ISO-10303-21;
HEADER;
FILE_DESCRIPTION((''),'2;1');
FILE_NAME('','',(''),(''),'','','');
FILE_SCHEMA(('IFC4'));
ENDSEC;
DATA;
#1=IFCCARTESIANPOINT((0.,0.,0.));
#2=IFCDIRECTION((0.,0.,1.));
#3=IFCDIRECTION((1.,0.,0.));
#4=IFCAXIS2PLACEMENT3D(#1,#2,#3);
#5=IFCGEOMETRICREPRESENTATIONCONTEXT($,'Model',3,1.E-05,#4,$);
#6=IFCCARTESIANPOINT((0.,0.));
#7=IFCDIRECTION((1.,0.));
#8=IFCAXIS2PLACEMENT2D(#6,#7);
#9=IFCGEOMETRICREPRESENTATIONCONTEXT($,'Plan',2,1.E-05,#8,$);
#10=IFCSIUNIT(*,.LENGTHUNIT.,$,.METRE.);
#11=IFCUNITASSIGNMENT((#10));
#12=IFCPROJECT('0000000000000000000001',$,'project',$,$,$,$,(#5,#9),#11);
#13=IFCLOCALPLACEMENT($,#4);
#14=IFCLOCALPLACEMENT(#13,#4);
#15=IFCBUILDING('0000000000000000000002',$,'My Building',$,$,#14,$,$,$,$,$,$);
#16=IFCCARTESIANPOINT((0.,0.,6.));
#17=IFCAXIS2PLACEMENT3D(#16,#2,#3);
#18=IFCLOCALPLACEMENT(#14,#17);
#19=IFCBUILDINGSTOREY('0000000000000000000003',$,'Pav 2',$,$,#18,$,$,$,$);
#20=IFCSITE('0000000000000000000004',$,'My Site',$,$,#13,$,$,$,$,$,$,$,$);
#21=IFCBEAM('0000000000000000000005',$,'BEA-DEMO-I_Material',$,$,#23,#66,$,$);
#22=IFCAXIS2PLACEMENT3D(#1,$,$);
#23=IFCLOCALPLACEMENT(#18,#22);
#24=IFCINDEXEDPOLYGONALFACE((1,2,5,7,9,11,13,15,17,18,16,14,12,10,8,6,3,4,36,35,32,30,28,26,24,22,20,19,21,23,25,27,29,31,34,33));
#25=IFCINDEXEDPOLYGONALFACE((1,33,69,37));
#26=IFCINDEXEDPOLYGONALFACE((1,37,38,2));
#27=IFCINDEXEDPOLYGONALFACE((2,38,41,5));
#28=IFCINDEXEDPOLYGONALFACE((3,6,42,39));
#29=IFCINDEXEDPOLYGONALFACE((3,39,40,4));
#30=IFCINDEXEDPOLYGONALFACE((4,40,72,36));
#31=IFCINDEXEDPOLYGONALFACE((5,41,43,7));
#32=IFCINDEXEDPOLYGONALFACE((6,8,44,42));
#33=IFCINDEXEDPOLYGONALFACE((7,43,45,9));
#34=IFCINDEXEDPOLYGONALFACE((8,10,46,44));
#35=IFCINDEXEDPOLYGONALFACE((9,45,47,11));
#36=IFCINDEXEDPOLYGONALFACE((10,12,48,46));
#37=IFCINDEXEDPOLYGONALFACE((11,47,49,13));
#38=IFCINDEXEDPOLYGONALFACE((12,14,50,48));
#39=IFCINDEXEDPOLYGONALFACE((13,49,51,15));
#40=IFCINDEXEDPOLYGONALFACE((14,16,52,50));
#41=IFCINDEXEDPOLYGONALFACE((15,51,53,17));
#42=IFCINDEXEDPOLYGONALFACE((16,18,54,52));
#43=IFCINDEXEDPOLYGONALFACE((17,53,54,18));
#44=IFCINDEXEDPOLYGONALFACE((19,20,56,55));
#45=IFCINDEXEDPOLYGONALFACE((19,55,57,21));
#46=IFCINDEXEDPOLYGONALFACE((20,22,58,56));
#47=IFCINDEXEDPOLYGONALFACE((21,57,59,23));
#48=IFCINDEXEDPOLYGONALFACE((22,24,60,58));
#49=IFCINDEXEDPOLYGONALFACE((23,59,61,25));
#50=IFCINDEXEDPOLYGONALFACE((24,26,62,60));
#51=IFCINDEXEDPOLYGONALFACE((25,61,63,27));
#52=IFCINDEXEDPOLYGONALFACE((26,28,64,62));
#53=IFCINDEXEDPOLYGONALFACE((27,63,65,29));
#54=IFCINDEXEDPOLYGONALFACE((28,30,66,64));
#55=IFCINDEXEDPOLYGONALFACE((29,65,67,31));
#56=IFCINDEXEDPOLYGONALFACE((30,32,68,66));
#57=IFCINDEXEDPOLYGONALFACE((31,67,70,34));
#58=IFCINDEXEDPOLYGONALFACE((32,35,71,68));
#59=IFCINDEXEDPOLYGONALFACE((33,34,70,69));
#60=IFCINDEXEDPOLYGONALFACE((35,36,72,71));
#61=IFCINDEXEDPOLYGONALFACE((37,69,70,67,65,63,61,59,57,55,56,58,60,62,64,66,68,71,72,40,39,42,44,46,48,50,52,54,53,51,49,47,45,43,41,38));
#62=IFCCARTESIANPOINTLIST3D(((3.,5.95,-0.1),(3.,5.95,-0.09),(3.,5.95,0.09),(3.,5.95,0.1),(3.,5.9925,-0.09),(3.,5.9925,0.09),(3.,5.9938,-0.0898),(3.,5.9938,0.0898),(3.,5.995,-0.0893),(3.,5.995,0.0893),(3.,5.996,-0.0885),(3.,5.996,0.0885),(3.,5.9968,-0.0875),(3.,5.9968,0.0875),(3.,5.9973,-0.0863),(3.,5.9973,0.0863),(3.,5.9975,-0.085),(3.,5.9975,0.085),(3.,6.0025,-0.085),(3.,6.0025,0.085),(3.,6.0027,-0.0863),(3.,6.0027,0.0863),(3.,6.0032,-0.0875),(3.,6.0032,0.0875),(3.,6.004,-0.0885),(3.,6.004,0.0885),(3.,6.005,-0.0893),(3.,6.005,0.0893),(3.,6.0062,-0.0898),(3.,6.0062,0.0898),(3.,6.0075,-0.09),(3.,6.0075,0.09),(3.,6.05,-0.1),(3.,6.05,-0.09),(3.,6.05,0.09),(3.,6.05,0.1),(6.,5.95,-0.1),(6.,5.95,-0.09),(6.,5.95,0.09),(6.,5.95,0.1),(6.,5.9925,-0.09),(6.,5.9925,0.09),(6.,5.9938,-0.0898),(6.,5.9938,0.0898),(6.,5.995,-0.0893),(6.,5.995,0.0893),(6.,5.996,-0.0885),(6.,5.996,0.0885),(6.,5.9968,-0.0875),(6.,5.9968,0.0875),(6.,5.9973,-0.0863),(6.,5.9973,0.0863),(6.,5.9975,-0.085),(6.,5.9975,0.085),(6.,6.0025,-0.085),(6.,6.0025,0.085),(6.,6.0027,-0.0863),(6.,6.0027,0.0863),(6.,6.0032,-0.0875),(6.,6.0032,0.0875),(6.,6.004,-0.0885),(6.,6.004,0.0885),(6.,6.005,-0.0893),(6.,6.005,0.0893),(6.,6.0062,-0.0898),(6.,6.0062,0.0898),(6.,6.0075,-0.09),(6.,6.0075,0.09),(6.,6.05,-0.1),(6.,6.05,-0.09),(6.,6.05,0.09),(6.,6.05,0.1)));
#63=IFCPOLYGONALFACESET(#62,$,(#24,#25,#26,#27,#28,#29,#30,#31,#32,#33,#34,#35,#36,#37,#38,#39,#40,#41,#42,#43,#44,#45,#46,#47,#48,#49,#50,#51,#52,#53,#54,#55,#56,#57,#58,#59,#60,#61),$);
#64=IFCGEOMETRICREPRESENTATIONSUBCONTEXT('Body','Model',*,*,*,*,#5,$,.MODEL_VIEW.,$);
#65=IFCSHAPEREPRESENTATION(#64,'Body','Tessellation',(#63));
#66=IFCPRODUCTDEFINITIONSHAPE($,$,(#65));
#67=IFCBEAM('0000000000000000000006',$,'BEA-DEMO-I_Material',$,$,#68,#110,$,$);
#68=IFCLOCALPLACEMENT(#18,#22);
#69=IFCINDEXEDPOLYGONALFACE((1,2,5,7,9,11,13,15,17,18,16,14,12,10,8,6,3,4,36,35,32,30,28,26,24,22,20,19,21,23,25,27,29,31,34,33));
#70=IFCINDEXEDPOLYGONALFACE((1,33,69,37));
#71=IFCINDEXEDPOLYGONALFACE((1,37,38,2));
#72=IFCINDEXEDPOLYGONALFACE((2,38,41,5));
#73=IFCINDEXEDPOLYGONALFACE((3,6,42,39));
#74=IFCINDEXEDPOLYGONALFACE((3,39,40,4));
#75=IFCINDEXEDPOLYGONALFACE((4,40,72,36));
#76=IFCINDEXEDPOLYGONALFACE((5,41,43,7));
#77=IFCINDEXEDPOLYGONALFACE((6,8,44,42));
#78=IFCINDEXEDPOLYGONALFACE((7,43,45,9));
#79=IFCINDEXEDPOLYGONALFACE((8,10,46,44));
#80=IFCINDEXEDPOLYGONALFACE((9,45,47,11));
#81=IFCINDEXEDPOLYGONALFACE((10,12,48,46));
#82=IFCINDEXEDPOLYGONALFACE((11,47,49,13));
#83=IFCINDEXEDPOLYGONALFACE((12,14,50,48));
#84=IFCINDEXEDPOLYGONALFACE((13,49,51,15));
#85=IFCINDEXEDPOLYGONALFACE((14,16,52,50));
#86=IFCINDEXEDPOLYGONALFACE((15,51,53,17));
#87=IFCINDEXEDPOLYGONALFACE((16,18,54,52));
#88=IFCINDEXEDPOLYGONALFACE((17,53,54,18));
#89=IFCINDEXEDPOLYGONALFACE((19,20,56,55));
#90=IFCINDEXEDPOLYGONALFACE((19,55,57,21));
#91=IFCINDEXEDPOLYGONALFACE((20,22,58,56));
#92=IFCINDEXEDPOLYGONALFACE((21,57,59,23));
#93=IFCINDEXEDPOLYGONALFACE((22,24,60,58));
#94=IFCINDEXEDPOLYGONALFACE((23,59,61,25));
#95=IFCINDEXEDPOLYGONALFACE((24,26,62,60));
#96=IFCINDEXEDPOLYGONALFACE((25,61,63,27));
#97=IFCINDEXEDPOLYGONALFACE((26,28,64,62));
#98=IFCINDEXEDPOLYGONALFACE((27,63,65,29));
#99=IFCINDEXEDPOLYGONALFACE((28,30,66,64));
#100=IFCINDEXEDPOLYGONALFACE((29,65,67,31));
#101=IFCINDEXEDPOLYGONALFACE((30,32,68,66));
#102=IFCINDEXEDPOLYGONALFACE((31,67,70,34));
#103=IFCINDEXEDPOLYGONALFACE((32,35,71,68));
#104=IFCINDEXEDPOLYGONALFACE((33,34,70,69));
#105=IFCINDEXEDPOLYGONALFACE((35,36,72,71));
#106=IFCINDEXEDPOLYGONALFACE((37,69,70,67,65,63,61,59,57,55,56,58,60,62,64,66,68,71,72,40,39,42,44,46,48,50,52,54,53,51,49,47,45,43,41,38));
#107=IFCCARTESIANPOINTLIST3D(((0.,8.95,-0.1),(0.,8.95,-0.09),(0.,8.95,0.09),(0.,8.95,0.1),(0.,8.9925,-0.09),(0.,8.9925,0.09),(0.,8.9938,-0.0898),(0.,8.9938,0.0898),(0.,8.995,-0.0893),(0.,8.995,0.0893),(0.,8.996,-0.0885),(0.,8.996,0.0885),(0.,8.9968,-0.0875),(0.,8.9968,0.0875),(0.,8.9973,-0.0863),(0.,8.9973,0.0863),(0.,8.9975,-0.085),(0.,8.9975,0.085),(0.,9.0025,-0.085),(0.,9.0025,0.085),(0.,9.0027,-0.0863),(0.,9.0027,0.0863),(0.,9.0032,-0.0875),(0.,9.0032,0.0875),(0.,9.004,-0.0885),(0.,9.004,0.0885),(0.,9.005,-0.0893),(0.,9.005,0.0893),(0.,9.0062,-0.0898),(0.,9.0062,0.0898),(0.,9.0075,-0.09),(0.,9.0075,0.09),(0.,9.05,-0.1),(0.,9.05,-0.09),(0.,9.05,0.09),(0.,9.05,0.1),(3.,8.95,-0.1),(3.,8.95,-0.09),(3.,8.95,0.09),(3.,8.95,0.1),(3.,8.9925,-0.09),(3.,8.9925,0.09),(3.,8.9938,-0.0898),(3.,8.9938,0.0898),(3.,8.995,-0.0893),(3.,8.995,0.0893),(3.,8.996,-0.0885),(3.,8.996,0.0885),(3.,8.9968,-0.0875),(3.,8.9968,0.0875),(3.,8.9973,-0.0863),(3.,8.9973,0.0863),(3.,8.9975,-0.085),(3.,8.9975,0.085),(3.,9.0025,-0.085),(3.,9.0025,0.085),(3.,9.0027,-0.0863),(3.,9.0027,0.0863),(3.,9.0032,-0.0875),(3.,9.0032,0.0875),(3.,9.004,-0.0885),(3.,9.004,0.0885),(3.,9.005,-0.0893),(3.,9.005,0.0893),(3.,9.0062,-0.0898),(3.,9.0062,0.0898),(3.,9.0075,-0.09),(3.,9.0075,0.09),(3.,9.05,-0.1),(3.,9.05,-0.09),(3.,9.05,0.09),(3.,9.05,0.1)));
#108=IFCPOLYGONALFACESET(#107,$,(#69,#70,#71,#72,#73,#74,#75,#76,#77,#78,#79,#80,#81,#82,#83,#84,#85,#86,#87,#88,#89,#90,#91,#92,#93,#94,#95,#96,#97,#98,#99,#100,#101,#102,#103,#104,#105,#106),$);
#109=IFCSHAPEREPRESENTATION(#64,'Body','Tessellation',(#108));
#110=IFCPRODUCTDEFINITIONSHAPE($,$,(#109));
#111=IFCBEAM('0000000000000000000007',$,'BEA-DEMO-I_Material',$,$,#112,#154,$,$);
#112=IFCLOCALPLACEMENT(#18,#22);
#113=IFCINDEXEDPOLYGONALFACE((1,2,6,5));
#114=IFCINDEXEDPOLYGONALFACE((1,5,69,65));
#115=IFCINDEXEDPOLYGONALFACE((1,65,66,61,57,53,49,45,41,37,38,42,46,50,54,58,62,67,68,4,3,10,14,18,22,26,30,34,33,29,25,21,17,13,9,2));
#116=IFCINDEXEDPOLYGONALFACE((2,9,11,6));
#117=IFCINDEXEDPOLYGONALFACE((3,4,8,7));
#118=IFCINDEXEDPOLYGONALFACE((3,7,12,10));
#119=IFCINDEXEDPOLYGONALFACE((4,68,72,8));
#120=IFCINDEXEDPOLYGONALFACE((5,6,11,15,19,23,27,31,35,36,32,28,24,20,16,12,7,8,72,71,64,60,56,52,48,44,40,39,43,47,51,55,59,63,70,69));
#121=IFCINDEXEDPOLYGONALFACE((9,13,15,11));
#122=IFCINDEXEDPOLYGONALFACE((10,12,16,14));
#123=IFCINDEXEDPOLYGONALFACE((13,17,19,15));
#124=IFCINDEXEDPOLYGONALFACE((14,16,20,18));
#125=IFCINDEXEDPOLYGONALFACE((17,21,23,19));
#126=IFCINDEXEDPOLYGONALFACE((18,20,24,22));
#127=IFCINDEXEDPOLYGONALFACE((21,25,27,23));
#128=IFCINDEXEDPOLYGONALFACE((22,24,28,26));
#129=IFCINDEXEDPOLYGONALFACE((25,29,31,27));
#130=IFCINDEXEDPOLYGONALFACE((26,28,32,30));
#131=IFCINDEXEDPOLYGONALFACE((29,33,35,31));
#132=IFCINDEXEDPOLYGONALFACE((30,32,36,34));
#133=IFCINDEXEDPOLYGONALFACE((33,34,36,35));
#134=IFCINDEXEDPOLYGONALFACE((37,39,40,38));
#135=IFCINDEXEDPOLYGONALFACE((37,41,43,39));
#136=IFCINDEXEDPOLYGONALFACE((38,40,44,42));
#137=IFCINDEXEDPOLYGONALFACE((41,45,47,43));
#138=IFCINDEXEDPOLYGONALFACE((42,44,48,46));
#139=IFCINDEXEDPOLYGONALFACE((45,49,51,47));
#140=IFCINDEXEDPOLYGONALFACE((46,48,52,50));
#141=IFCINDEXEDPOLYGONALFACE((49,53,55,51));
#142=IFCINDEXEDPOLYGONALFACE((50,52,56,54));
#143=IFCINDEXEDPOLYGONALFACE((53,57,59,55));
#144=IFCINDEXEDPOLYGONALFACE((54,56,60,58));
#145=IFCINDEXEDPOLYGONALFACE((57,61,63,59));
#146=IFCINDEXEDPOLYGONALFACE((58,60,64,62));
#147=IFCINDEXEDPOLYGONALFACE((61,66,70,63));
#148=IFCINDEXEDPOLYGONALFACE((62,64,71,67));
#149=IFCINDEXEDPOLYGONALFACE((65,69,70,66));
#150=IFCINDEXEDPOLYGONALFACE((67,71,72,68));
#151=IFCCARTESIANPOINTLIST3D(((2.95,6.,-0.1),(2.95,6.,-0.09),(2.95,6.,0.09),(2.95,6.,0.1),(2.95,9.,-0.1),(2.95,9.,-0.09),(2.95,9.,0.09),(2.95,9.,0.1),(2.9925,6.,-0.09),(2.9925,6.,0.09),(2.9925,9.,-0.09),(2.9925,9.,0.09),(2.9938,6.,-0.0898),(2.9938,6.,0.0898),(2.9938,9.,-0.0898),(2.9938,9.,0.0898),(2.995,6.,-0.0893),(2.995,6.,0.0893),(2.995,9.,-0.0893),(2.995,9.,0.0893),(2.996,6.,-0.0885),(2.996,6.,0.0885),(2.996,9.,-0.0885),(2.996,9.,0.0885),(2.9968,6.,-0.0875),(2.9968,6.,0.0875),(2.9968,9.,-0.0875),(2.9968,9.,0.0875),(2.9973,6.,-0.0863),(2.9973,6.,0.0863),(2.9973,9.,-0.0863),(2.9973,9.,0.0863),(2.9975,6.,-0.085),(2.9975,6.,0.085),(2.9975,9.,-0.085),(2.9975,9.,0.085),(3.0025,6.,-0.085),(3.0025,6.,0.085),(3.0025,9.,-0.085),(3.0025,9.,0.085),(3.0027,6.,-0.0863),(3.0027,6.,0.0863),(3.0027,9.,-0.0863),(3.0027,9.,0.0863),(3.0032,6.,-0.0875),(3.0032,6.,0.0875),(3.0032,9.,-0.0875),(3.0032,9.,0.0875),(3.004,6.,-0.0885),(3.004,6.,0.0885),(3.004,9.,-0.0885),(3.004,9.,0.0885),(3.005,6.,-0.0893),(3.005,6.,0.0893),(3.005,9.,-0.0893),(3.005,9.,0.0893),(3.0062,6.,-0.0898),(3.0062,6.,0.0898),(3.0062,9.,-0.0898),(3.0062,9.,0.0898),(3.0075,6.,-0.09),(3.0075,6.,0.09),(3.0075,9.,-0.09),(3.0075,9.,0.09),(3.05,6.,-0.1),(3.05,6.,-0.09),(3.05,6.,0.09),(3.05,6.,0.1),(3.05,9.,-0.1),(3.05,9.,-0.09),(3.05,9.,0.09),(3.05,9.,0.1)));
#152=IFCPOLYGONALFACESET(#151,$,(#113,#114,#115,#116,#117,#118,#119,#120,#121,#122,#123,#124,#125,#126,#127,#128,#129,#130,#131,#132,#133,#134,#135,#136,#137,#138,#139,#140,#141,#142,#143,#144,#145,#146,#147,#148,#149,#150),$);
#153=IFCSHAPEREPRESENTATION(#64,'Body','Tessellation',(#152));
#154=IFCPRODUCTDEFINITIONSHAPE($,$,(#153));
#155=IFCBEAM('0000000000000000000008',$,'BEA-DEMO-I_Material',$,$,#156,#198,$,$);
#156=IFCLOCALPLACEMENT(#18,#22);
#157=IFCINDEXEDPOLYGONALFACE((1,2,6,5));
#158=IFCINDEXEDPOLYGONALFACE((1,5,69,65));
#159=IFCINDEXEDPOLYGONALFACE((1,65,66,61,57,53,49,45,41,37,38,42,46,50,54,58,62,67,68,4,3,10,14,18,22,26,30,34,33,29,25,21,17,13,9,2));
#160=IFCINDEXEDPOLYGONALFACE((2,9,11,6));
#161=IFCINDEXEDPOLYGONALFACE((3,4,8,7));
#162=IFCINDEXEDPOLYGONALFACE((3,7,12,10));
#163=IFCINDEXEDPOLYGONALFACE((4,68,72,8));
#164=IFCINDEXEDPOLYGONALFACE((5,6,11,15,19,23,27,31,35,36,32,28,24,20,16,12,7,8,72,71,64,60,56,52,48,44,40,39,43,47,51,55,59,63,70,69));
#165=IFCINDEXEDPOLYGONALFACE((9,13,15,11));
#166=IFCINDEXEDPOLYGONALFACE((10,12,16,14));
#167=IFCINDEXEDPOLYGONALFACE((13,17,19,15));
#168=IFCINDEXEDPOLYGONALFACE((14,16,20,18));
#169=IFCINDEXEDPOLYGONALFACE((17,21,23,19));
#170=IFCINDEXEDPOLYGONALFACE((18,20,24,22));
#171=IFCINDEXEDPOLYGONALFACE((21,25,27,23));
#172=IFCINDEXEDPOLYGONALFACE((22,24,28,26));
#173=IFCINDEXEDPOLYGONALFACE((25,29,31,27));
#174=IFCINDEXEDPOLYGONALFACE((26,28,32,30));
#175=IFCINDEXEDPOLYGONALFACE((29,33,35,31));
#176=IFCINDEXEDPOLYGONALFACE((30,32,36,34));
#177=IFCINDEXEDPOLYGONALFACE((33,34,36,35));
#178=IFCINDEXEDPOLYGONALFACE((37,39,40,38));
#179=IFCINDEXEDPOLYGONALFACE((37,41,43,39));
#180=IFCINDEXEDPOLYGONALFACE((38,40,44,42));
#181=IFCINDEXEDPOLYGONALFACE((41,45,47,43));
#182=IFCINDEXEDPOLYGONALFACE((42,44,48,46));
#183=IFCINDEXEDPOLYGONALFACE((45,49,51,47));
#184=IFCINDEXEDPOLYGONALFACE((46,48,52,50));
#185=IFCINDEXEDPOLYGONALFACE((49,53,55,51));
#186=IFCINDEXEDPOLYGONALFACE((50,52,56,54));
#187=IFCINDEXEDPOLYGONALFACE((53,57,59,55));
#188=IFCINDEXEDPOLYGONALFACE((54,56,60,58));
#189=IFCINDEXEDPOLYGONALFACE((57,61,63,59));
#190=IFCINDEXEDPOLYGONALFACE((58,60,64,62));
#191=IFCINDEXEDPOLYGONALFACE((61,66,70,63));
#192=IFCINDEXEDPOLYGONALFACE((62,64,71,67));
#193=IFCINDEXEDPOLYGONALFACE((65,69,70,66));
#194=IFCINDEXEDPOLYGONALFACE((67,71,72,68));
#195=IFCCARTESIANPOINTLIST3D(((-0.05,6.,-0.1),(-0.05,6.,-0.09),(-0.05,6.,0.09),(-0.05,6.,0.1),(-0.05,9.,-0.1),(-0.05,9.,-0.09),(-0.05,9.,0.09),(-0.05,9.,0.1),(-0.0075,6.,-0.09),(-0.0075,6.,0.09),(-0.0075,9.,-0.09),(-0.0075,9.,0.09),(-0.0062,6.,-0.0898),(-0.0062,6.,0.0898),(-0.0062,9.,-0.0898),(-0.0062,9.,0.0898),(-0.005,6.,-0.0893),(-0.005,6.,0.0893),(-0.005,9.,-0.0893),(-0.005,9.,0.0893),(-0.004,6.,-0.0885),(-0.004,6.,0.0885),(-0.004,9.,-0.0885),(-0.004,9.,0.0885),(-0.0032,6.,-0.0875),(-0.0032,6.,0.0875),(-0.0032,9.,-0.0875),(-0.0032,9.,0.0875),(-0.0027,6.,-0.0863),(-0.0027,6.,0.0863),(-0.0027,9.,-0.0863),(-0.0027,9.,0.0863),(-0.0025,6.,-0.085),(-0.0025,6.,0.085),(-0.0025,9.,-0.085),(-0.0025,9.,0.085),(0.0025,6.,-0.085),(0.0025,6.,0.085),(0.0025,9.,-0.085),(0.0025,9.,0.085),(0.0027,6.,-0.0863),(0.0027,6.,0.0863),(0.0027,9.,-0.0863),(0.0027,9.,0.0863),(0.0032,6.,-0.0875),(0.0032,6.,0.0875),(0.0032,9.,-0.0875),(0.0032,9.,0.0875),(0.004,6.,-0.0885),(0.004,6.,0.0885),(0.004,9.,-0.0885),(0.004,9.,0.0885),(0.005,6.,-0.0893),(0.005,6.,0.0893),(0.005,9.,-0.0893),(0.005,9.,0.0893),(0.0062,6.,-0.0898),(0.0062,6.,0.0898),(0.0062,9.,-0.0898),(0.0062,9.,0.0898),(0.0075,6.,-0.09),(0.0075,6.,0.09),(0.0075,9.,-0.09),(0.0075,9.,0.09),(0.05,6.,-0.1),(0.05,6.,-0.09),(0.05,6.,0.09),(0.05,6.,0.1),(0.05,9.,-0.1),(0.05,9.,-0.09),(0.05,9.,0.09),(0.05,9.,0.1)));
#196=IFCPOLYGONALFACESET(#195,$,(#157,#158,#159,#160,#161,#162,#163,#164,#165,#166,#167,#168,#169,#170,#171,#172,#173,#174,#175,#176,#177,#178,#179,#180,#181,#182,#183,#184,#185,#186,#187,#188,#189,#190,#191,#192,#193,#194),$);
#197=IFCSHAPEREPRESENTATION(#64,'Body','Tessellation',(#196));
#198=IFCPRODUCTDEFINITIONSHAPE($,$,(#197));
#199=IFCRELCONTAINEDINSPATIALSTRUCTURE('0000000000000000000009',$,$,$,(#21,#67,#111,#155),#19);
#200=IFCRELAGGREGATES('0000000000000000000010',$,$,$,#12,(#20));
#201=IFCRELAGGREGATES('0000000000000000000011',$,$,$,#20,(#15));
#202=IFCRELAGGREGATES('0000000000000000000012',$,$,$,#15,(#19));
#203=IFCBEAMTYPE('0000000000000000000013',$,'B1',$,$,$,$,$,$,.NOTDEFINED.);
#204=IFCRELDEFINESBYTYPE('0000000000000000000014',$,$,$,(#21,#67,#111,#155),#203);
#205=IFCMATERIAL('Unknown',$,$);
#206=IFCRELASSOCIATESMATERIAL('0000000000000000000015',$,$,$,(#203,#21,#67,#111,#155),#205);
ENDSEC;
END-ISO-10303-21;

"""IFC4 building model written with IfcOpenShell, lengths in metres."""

from ifc_helpers import new_model, si_unit, frame, origin, origin_with_axes, origin_2d_with_axis, place, context, subcontext, project, spatial, i_section, extrude, material, material_profile, profile_set, profile_usage, type_object, element, save


model = new_model("IFC4")

# Units and contexts
model_context = context("Model", 3, precision=1e-05, world=origin_with_axes())
plan_context = context("Plan", 2, precision=1e-05, world=origin_2d_with_axis())
body_context = subcontext(model_context, "Body", "Model", "MODEL_VIEW")
ifc_project = project(units=[si_unit("LENGTHUNIT", "METRE")], contexts=[model_context, plan_context])

# Site, building, storey
site_placement = place(None, origin_with_axes())
site = spatial("IfcSite", under=ifc_project, at=site_placement, Name="My Site")
building_placement = place(site_placement, origin_with_axes())
building = spatial("IfcBuilding", under=site, at=building_placement, Name="My Building")
storey_placement = place(building_placement, frame((0.0, 0.0, 6.0), z_axis=(0.0, 0.0, 1.0), x_axis=(1.0, 0.0, 0.0)))
storey = spatial("IfcBuildingStorey", under=building, at=storey_placement, Name="Pav 2")

# Beams
ifc_material = material(Name="Unknown")
ifc_material_profile = material_profile(ifc_material, i_section(OverallWidth=0.1, OverallDepth=0.2, WebThickness=0.005, FlangeThickness=0.01, FilletRadius=0.005))
ifc_profile_set = profile_set([ifc_material_profile])
beam_type = type_object("IfcBeamType", Name="B1", PredefinedType="NOTDEFINED", material=ifc_profile_set)
ifc_profile_usage_1 = profile_usage(ifc_profile_set, cardinal=5)
beam_1_placement = place(storey_placement, frame((3.0, 6.0, 0.0), z_axis=(1.0, 0.0, 0.0), x_axis=(0.0, 1.0, 0.0)))
element("IfcBeam", 1, at=beam_1_placement, inside=storey, type_object=beam_type, material=ifc_profile_usage_1, Name="BEA-DEMO-I_Material", context=body_context, shape_type="SweptSolid", body=[
    extrude(i_section(OverallWidth=0.1, OverallDepth=0.2, WebThickness=0.005, FlangeThickness=0.01, FilletRadius=0.005), origin(), (0.0, 0.0, 1.0), 3.0),
])
ifc_profile_usage_2 = profile_usage(ifc_profile_set, cardinal=5)
beam_2_placement = place(storey_placement, frame((0.0, 9.0, 0.0), z_axis=(1.0, 0.0, 0.0), x_axis=(0.0, 1.0, 0.0)))
element("IfcBeam", 2, at=beam_2_placement, inside=storey, type_object=beam_type, material=ifc_profile_usage_2, Name="BEA-DEMO-I_Material", context=body_context, shape_type="SweptSolid", body=[
    extrude(i_section(OverallWidth=0.1, OverallDepth=0.2, WebThickness=0.005, FlangeThickness=0.01, FilletRadius=0.005), origin(), (0.0, 0.0, 1.0), 3.0),
])
ifc_profile_usage_3 = profile_usage(ifc_profile_set, cardinal=5)
beam_3_placement = place(storey_placement, frame((3.0, 9.0, 0.0), z_axis=(0.0, -1.0, 0.0), x_axis=(1.0, 0.0, 0.0)))
element("IfcBeam", 3, at=beam_3_placement, inside=storey, type_object=beam_type, material=ifc_profile_usage_3, Name="BEA-DEMO-I_Material", context=body_context, shape_type="SweptSolid", body=[
    extrude(i_section(OverallWidth=0.1, OverallDepth=0.2, WebThickness=0.005, FlangeThickness=0.01, FilletRadius=0.005), origin(), (0.0, 0.0, 1.0), 3.0),
])
ifc_profile_usage_4 = profile_usage(ifc_profile_set, cardinal=5)
beam_4_placement = place(storey_placement, frame((0.0, 6.0, 0.0), z_axis=(0.0, 1.0, 0.0), x_axis=(-1.0, 0.0, 0.0)))
element("IfcBeam", 4, at=beam_4_placement, inside=storey, type_object=beam_type, material=ifc_profile_usage_4, Name="BEA-DEMO-I_Material", context=body_context, shape_type="SweptSolid", body=[
    extrude(i_section(OverallWidth=0.1, OverallDepth=0.2, WebThickness=0.005, FlangeThickness=0.01, FilletRadius=0.005), origin(), (0.0, 0.0, 1.0), 3.0),
])

save(model, "model.ifc")
